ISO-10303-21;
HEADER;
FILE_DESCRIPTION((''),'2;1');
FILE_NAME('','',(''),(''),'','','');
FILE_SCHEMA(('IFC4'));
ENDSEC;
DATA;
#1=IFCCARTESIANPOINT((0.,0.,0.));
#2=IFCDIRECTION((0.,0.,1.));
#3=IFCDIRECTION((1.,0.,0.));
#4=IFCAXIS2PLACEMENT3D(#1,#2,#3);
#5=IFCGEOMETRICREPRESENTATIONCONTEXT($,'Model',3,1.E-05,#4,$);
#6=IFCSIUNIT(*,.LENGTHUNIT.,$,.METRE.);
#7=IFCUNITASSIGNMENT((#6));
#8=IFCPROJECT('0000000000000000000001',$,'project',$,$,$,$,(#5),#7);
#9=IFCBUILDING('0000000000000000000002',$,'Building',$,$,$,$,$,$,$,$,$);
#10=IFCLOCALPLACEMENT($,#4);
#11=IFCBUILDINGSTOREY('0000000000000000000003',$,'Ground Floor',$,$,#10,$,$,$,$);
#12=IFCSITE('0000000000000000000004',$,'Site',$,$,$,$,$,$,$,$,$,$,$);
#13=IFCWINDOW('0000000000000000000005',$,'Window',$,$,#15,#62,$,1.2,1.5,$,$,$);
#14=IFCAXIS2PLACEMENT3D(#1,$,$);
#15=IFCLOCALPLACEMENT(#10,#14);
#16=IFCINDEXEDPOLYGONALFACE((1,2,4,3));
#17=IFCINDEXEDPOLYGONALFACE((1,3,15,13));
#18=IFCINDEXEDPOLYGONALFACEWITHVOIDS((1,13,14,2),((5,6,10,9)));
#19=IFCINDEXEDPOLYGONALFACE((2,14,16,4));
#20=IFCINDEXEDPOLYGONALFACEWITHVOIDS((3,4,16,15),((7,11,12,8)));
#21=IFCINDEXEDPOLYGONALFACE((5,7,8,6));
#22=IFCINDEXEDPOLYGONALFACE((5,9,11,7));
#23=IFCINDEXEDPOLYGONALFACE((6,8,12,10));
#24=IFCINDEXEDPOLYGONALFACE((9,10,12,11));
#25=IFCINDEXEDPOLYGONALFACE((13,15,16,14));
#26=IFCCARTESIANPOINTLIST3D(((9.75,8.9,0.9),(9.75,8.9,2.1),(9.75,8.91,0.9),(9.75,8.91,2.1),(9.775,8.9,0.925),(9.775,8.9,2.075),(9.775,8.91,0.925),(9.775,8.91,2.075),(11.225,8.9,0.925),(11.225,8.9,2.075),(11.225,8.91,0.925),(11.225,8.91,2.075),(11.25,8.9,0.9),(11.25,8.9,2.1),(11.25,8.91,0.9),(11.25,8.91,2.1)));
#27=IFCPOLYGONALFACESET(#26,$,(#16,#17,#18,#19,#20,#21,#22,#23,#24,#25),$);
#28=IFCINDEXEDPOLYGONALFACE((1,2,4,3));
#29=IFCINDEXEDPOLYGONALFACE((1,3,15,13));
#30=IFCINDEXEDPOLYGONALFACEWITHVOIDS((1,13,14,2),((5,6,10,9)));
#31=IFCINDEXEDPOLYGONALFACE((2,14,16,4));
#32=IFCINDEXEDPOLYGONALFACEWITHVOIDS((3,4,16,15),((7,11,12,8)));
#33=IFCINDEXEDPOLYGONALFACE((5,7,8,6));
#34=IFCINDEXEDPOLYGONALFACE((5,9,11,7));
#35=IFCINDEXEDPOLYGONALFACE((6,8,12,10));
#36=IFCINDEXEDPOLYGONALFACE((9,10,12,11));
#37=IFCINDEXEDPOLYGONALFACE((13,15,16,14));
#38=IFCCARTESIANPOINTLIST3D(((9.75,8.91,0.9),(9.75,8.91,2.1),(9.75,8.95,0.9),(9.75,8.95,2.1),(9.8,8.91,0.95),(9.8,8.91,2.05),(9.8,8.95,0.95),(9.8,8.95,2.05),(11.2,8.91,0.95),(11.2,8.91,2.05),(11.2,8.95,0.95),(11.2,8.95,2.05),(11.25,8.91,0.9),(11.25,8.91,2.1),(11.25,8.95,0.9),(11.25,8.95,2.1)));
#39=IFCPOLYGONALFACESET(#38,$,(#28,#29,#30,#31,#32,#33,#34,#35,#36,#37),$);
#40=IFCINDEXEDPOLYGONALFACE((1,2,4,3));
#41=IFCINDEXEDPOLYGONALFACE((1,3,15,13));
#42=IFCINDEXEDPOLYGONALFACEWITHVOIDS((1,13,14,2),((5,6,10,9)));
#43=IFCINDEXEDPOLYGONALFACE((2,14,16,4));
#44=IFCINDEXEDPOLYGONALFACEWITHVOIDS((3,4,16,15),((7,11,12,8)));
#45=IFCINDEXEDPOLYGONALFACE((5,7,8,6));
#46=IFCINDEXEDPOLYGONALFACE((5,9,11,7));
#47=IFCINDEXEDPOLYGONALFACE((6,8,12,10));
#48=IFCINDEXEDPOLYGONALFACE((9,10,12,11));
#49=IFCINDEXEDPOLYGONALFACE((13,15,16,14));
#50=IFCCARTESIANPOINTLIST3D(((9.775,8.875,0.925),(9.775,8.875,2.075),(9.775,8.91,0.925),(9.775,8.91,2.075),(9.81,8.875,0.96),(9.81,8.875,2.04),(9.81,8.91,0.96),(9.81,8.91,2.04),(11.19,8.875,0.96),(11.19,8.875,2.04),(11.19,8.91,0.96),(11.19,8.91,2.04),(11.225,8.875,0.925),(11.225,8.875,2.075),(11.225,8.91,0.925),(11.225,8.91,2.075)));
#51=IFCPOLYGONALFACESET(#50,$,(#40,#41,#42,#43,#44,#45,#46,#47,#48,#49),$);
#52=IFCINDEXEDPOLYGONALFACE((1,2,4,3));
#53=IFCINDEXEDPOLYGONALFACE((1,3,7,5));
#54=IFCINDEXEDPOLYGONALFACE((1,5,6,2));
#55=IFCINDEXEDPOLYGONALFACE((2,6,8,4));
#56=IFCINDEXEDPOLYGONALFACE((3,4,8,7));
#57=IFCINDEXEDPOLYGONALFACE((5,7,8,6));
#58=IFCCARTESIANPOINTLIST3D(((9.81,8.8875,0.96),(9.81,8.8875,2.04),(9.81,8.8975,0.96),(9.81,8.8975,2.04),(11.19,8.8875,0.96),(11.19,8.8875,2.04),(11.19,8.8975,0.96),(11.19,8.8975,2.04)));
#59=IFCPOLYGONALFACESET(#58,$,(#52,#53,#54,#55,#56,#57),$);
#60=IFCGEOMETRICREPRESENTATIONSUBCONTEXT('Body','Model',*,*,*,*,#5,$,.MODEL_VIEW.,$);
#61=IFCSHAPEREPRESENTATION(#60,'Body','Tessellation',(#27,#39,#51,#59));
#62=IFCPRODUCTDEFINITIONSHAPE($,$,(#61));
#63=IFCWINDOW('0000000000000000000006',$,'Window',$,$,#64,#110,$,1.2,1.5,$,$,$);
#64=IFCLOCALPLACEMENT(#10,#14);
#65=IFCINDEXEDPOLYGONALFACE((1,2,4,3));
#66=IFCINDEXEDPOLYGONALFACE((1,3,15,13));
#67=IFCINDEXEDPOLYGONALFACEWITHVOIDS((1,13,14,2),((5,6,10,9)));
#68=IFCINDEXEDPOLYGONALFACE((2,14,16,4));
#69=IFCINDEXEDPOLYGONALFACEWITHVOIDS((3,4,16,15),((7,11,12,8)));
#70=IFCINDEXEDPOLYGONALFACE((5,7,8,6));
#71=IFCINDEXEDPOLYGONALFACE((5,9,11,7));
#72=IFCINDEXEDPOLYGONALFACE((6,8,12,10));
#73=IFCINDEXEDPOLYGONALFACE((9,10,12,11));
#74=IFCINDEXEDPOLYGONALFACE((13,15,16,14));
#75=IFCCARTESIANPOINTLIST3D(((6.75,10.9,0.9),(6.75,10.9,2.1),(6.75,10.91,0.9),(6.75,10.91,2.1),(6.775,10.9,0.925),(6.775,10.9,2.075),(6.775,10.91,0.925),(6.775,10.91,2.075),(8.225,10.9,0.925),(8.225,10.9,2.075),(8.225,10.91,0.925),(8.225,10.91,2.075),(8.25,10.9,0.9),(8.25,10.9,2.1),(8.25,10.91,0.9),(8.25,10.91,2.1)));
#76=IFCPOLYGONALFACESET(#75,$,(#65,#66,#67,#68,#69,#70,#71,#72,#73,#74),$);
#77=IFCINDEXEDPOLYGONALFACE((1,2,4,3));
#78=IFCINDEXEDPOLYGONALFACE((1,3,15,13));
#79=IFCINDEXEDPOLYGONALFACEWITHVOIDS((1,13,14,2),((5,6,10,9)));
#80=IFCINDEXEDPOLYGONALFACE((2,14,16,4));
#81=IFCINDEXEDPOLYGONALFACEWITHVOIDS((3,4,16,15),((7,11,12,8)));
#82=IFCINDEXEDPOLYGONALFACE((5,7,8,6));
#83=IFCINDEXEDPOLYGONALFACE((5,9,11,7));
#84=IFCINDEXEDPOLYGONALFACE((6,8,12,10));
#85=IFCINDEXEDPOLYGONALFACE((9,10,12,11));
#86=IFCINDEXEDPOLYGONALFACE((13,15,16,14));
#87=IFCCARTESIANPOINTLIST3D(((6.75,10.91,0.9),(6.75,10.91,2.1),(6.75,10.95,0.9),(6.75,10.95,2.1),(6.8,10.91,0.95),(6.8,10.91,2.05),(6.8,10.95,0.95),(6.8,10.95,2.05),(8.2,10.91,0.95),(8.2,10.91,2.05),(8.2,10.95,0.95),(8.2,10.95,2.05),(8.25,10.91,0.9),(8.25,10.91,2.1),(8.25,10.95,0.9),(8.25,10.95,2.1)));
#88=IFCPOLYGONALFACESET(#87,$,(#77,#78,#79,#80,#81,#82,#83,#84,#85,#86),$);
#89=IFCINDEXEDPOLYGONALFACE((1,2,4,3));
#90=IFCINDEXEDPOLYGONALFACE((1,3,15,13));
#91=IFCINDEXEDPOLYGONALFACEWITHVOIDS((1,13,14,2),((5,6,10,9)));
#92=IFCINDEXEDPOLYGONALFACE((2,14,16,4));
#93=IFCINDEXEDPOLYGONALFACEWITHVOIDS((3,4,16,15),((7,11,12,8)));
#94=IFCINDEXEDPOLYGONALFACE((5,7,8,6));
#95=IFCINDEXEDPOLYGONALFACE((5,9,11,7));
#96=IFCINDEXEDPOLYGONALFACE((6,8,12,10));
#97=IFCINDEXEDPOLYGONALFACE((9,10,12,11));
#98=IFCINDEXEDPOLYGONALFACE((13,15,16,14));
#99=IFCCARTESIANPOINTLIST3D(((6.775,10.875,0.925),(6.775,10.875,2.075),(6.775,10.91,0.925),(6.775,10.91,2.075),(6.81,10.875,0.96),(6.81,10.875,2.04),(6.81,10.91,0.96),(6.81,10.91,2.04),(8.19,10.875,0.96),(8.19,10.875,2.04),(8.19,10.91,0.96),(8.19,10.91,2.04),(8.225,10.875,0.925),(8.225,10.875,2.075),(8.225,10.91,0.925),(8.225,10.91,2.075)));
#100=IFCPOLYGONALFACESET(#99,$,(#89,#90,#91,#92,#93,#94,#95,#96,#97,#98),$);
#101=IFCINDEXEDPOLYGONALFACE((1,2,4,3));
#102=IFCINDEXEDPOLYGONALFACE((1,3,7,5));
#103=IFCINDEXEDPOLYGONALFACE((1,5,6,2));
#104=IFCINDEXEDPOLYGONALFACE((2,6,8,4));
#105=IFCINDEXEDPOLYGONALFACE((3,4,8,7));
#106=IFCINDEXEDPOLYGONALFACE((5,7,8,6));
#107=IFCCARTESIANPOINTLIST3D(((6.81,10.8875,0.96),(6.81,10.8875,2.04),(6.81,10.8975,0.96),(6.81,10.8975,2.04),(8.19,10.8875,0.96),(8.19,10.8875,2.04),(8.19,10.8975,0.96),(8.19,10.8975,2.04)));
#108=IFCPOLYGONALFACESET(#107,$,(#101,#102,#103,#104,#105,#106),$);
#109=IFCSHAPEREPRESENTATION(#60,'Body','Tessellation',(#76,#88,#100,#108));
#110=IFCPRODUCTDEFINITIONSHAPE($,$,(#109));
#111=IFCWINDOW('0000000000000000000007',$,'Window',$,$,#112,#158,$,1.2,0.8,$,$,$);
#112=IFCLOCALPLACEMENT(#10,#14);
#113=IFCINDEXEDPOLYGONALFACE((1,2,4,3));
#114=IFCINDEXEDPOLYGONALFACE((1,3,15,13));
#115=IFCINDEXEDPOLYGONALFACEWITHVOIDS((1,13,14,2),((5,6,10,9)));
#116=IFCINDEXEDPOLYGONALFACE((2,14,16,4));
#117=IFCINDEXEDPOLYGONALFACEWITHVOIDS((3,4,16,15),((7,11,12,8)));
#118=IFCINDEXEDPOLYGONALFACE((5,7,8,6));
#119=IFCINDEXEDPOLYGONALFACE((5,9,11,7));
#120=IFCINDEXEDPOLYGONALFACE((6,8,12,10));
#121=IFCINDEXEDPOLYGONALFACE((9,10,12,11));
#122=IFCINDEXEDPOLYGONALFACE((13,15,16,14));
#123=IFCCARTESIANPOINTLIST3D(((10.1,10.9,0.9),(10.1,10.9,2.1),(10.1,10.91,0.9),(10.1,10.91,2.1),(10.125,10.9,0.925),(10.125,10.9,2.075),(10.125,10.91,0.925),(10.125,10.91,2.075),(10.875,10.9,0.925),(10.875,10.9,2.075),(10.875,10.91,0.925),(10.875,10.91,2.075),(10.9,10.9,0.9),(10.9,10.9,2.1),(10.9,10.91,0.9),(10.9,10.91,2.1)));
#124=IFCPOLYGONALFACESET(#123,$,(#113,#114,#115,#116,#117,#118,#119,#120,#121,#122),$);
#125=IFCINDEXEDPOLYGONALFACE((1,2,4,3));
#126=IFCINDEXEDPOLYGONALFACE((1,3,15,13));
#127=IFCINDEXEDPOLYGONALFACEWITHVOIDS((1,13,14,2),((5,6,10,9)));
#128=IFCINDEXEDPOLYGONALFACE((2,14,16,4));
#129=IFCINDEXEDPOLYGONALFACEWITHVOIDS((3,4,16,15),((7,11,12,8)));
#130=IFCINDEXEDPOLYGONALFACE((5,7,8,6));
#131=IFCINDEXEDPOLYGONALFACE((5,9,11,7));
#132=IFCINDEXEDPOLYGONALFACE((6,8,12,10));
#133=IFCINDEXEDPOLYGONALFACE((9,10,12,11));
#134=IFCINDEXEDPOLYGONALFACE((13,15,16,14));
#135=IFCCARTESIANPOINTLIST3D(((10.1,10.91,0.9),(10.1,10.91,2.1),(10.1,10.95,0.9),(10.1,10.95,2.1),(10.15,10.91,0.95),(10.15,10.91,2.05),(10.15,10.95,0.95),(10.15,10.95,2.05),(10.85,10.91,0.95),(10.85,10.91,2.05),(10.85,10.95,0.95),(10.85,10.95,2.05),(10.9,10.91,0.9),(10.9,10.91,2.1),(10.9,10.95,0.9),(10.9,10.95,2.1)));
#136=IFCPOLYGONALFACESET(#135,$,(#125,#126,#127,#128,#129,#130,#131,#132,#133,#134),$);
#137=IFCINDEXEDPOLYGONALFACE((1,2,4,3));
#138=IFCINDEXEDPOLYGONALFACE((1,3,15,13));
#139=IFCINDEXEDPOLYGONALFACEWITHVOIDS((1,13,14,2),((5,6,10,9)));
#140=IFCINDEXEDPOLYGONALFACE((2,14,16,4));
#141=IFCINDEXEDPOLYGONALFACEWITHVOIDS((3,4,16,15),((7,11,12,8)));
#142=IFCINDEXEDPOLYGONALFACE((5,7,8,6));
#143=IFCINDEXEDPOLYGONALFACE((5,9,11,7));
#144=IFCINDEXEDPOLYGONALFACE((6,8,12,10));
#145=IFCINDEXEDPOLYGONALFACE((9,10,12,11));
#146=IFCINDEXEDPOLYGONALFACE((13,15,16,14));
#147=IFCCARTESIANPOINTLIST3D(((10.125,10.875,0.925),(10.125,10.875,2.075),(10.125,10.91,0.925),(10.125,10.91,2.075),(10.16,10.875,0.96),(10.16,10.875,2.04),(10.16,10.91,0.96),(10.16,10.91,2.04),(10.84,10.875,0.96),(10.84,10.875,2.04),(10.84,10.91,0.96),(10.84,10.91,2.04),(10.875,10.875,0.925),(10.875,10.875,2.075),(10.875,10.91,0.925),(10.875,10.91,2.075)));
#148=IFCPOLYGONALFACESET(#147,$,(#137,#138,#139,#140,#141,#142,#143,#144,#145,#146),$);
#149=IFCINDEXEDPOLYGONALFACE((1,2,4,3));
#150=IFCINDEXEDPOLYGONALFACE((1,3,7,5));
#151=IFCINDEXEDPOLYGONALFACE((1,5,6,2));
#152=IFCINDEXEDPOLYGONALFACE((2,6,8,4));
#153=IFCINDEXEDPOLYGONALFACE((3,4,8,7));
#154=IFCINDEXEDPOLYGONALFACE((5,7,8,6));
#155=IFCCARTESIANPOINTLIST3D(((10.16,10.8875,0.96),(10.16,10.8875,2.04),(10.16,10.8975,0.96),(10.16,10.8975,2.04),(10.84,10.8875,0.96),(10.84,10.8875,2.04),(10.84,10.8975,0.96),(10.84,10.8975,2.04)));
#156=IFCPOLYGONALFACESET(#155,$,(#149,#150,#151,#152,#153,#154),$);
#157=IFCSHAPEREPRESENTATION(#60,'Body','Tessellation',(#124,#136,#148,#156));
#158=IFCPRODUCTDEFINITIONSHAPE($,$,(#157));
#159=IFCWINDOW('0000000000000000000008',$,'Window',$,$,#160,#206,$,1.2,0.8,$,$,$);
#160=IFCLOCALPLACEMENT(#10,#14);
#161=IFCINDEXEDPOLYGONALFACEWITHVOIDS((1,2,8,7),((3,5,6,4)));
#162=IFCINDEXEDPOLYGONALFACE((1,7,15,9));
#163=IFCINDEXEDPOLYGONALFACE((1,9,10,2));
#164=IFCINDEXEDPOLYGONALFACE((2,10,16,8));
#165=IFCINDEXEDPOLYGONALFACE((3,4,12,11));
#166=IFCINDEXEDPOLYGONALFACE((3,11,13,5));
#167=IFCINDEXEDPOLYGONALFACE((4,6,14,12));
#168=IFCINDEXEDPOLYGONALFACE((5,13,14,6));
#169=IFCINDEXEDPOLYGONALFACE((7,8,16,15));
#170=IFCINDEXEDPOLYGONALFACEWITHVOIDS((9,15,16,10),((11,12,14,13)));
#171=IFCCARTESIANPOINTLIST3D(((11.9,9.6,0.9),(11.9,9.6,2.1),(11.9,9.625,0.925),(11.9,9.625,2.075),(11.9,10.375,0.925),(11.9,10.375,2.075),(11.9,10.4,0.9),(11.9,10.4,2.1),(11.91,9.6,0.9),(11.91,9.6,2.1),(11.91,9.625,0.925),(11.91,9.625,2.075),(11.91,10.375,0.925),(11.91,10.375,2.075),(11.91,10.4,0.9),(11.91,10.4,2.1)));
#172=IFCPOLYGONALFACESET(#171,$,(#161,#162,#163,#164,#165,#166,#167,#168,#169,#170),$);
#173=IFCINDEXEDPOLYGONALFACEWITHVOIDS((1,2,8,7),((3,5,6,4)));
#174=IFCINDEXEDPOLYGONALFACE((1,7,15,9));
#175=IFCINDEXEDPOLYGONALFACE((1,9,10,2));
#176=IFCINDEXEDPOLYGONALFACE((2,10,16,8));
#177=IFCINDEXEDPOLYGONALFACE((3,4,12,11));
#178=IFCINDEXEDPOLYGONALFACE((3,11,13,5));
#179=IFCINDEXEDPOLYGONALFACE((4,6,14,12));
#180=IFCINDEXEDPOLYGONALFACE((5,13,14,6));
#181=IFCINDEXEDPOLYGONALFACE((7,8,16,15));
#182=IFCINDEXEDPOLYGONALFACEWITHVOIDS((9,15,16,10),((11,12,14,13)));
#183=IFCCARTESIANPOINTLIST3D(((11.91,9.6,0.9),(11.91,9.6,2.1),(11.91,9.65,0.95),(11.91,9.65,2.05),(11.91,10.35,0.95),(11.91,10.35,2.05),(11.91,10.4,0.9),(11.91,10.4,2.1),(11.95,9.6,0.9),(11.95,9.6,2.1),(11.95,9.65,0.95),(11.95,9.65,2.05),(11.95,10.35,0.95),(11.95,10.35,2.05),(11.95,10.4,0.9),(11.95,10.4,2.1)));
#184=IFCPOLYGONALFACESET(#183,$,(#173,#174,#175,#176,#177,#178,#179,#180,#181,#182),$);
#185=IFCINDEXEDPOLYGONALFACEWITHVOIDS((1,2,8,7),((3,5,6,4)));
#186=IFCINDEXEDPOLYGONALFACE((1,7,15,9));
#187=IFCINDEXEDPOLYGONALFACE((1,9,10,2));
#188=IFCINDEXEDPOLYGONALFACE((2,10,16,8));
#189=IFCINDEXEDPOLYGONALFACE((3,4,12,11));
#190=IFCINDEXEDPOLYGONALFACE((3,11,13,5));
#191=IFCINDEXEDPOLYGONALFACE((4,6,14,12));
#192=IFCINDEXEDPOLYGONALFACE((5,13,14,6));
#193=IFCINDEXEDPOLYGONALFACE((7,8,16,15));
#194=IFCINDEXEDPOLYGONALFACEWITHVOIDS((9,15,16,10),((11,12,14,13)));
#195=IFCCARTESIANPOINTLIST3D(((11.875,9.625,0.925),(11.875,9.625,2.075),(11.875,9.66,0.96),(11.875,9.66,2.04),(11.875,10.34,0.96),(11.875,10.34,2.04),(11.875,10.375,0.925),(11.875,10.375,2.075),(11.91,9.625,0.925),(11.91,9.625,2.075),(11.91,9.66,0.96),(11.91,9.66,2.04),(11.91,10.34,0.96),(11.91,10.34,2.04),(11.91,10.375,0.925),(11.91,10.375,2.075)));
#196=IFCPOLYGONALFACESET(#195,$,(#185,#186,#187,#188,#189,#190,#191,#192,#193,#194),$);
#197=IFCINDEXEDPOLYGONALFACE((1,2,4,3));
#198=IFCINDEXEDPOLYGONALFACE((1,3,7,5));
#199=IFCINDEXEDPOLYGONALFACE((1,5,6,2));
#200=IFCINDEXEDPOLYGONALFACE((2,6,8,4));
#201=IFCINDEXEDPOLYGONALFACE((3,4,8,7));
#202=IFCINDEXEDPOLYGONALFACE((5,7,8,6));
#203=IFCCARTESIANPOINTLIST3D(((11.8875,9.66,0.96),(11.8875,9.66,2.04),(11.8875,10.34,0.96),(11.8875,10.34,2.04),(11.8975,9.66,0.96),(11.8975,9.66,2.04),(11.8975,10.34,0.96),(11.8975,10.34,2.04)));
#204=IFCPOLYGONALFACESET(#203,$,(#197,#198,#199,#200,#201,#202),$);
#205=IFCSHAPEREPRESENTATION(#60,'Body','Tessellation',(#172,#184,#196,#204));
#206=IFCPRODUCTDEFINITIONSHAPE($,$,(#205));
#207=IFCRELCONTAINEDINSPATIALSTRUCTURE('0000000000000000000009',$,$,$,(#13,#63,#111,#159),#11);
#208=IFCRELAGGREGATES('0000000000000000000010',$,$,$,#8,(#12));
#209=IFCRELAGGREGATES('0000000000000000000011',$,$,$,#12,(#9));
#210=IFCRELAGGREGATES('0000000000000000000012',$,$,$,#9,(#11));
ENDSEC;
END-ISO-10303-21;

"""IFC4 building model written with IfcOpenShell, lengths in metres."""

from ifc_helpers import new_model, si_unit, frame, origin_with_axes, place, context, subcontext, project, spatial, line, indexed_curve, outline, extrude, element, save


model = new_model("IFC4")

# Units and contexts
model_context = context("Model", 3, precision=1e-05, world=origin_with_axes())
body_context = subcontext(model_context, "Body", "Model", "MODEL_VIEW")
ifc_project = project(units=[si_unit("LENGTHUNIT", "METRE")], contexts=[model_context])

# Site, building, storey
site = spatial("IfcSite", under=ifc_project, Name="Site")
building = spatial("IfcBuilding", under=site, Name="Building")
storey_placement = place(None, origin_with_axes())
storey = spatial("IfcBuildingStorey", under=building, at=storey_placement, Name="Ground Floor")

# Windows
for number, where, z_axis, x_axis, name in (
    (1, (11.25, 9.0, 0.9), (0.0, 0.0, 1.0), (-1.0, 0.0, 0.0), "Window"),
    (2, (8.25, 11.0, 0.9), (0.0, 0.0, 1.0), (-1.0, 0.0, 0.0), "Window"),
):
    element("IfcWindow", number, at=place(storey_placement, frame(where, z_axis=z_axis, x_axis=x_axis)), inside=storey, Name=name, OverallHeight=1.2, OverallWidth=1.5, context=body_context, shape_type="SweptSolid", body=[
        extrude(outline(indexed_curve([(0.0, 0.0), (1.5, 0.0), (1.5, 1.2), (0.0, 1.2)], segments=[line(1, 2, 3, 4, 1)]), holes=[indexed_curve([(0.025, 0.025), (1.475, 0.025), (1.475, 1.175), (0.025, 1.175)], segments=[line(1, 2, 3, 4, 1)])]), frame((0.0, 0.09, 0.0), z_axis=(0.0, -1.0, 0.0), x_axis=(1.0, 0.0, 0.0)), (0.0, 0.0, -1.0), 0.01),
        extrude(outline(indexed_curve([(0.0, 0.0), (1.5, 0.0), (1.5, 1.2), (0.0, 1.2)], segments=[line(1, 2, 3, 4, 1)]), holes=[indexed_curve([(0.05, 0.05), (1.45, 0.05), (1.45, 1.15), (0.05, 1.15)], segments=[line(1, 2, 3, 4, 1)])]), frame((0.0, 0.05, 0.0), z_axis=(0.0, -1.0, 0.0), x_axis=(1.0, 0.0, 0.0)), (0.0, 0.0, -1.0), 0.04),
        extrude(outline(indexed_curve([(0.0, 0.0), (1.45, 0.0), (1.45, 1.15), (0.0, 1.15)], segments=[line(1, 2, 3, 4, 1)]), holes=[indexed_curve([(0.035, 0.035), (1.415, 0.035), (1.415, 1.115), (0.035, 1.115)], segments=[line(1, 2, 3, 4, 1)])]), frame((0.025, 0.09, 0.025), z_axis=(0.0, -1.0, 0.0), x_axis=(1.0, 0.0, 0.0)), (0.0, 0.0, -1.0), 0.035),
        extrude(outline(indexed_curve([(0.035, 0.035), (1.415, 0.035), (1.415, 1.115), (0.035, 1.115)], segments=[line(1, 2, 3, 4, 1)])), frame((0.025, 0.1025, 0.025), z_axis=(0.0, -1.0, 0.0), x_axis=(1.0, 0.0, 0.0)), (0.0, 0.0, -1.0), 0.01),
    ])
for number, where, z_axis, x_axis, name in (
    (3, (10.9, 11.0, 0.9), (0.0, 0.0, 1.0), (-1.0, 0.0, 0.0), "Window"),
    (4, (12.0, 9.6, 0.9), (0.0, 0.0, 1.0), (0.0, 1.0, 0.0), "Window"),
):
    element("IfcWindow", number, at=place(storey_placement, frame(where, z_axis=z_axis, x_axis=x_axis)), inside=storey, Name=name, OverallHeight=1.2, OverallWidth=0.8, context=body_context, shape_type="SweptSolid", body=[
        extrude(outline(indexed_curve([(0.0, 0.0), (0.8, 0.0), (0.8, 1.2), (0.0, 1.2)], segments=[line(1, 2, 3, 4, 1)]), holes=[indexed_curve([(0.025, 0.025), (0.775, 0.025), (0.775, 1.175), (0.025, 1.175)], segments=[line(1, 2, 3, 4, 1)])]), frame((0.0, 0.09, 0.0), z_axis=(0.0, -1.0, 0.0), x_axis=(1.0, 0.0, 0.0)), (0.0, 0.0, -1.0), 0.01),
        extrude(outline(indexed_curve([(0.0, 0.0), (0.8, 0.0), (0.8, 1.2), (0.0, 1.2)], segments=[line(1, 2, 3, 4, 1)]), holes=[indexed_curve([(0.05, 0.05), (0.75, 0.05), (0.75, 1.15), (0.05, 1.15)], segments=[line(1, 2, 3, 4, 1)])]), frame((0.0, 0.05, 0.0), z_axis=(0.0, -1.0, 0.0), x_axis=(1.0, 0.0, 0.0)), (0.0, 0.0, -1.0), 0.04),
        extrude(outline(indexed_curve([(0.0, 0.0), (0.75, 0.0), (0.75, 1.15), (0.0, 1.15)], segments=[line(1, 2, 3, 4, 1)]), holes=[indexed_curve([(0.035, 0.035), (0.715, 0.035), (0.715, 1.115), (0.035, 1.115)], segments=[line(1, 2, 3, 4, 1)])]), frame((0.025, 0.09, 0.025), z_axis=(0.0, -1.0, 0.0), x_axis=(1.0, 0.0, 0.0)), (0.0, 0.0, -1.0), 0.035),
        extrude(outline(indexed_curve([(0.035, 0.035), (0.715, 0.035), (0.715, 1.115), (0.035, 1.115)], segments=[line(1, 2, 3, 4, 1)])), frame((0.025, 0.1025, 0.025), z_axis=(0.0, -1.0, 0.0), x_axis=(1.0, 0.0, 0.0)), (0.0, 0.0, -1.0), 0.01),
    ])

save(model, "model.ifc")
